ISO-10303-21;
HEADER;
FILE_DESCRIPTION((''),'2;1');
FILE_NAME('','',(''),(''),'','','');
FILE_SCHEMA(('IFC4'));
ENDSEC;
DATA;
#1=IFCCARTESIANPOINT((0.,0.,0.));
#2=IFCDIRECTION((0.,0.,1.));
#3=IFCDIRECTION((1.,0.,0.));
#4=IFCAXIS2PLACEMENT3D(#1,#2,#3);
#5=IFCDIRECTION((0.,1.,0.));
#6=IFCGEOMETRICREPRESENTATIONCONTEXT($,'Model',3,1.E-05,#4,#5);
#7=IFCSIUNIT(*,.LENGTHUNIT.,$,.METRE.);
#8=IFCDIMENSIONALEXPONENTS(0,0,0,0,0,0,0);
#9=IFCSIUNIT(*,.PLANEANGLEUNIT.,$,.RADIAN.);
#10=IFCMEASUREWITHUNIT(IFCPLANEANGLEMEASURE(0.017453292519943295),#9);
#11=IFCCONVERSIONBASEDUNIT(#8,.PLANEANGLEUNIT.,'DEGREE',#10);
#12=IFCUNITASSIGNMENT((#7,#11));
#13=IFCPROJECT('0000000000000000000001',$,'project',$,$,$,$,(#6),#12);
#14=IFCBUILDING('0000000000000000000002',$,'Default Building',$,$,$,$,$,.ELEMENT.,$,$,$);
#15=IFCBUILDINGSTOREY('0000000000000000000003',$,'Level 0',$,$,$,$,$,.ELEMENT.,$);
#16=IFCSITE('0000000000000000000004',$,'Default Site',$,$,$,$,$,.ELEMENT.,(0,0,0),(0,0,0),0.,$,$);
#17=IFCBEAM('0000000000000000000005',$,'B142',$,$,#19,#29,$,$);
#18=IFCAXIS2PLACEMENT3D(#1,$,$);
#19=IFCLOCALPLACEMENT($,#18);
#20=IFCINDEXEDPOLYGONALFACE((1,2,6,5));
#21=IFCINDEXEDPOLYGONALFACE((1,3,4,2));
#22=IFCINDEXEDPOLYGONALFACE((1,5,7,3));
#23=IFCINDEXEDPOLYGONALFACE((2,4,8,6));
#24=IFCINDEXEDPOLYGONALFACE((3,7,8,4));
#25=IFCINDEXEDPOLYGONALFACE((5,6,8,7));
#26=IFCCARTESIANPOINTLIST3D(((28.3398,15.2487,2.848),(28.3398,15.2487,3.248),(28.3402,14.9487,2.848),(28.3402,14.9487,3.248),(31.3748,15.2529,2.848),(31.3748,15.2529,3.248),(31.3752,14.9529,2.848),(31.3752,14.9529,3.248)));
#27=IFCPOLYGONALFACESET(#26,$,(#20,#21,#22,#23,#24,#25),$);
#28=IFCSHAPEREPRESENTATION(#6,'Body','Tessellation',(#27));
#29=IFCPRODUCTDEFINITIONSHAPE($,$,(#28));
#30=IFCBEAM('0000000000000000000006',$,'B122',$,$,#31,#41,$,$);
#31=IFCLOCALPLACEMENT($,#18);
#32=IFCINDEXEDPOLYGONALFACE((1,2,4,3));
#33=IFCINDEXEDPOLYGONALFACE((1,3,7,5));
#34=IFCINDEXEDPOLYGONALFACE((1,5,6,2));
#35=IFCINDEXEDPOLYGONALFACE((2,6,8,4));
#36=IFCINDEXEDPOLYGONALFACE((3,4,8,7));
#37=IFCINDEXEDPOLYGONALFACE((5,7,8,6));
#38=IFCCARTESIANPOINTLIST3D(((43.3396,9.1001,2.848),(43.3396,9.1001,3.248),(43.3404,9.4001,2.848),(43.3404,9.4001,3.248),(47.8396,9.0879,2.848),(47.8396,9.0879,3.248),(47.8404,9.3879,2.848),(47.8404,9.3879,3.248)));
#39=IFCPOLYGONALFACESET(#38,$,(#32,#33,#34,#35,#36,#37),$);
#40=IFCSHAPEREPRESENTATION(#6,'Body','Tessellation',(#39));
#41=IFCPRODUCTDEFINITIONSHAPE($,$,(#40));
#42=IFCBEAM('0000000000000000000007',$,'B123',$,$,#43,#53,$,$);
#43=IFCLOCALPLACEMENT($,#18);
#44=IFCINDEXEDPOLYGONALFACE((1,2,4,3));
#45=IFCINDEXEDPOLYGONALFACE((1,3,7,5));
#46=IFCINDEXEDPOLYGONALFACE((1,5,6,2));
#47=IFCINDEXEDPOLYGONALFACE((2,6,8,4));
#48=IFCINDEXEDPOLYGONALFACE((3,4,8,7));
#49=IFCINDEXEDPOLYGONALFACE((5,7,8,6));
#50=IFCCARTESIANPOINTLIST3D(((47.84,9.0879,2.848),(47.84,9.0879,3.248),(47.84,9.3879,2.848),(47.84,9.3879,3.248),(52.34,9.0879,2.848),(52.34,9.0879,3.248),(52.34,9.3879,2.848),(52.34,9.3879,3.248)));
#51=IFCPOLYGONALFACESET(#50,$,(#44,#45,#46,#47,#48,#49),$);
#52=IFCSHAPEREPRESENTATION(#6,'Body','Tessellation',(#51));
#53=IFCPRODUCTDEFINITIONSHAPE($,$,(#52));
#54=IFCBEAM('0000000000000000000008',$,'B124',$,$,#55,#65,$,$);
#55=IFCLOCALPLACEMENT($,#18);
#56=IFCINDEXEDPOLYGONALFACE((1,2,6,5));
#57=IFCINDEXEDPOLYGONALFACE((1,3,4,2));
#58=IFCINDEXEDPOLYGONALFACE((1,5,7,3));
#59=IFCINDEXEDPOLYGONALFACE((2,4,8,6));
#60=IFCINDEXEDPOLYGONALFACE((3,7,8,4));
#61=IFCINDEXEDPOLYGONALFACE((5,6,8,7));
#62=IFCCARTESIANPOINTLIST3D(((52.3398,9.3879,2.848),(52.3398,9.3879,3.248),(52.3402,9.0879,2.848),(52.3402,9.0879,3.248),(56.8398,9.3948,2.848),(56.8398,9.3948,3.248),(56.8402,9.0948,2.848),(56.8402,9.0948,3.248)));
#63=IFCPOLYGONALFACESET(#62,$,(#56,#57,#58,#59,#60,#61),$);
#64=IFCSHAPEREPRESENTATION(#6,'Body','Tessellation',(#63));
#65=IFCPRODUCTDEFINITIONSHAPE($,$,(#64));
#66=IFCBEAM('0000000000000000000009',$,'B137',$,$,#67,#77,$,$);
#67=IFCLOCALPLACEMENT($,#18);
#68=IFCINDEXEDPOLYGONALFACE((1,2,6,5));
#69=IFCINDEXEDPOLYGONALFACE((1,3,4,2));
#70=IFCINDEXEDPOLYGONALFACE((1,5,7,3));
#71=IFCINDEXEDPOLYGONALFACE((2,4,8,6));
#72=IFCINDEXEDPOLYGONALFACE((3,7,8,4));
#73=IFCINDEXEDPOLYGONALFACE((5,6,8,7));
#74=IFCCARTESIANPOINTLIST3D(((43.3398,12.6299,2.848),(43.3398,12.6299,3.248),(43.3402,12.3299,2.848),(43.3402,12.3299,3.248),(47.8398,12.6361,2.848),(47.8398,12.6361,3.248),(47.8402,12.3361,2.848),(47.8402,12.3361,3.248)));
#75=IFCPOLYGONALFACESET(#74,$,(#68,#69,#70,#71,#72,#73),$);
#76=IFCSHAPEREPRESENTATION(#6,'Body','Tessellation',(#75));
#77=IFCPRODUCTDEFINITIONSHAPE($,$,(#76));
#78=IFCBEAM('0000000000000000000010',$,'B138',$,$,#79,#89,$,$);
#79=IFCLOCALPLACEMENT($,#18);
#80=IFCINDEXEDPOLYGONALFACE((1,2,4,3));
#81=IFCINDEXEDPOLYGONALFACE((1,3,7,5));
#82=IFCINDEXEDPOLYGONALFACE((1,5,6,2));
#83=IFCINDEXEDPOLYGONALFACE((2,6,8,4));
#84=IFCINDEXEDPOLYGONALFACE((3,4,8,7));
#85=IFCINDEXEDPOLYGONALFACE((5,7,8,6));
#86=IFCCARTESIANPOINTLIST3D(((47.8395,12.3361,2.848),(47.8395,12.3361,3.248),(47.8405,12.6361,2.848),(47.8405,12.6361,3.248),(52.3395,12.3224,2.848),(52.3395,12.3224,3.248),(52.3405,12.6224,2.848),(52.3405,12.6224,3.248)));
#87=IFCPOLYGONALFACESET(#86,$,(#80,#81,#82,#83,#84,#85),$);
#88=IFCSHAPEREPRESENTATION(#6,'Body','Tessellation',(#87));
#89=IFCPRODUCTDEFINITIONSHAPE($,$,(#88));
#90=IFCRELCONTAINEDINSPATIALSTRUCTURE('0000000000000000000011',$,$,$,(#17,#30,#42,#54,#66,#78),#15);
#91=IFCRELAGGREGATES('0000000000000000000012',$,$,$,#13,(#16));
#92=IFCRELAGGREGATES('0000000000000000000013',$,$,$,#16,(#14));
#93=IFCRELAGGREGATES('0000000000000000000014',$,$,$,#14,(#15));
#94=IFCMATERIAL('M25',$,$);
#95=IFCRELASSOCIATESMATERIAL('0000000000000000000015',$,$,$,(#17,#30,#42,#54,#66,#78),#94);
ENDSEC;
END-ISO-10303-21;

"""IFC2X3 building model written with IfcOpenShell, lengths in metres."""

from ifc_helpers import new_model, entity, si_unit, converted_unit, direction, frame, frame_2d, origin_with_axes, place, context, project, spatial, rectangle, extrude, material, element, save


model = new_model("IFC2X3")

# Units and contexts
model_context = context("Model", 3, precision=1e-05, world=origin_with_axes(), true_north=direction((0.0, 1.0, 0.0)))
ifc_project = project(units=[si_unit("LENGTHUNIT", "METRE"), converted_unit("PLANEANGLEUNIT", "DEGREE", entity("IfcPlaneAngleMeasure", 0.017453292519943295), si_unit("PLANEANGLEUNIT", "RADIAN"), dimensions=[0, 0, 0, 0, 0, 0, 0])], contexts=[model_context])

# Site, building, storey
site = spatial("IfcSite", under=ifc_project, Name="Default Site", CompositionType="ELEMENT", RefLatitude=(0, 0, 0), RefLongitude=(0, 0, 0), RefElevation=0.0)
building = spatial("IfcBuilding", under=site, Name="Default Building", CompositionType="ELEMENT")
storey = spatial("IfcBuildingStorey", under=building, Name="Level 0", CompositionType="ELEMENT")

# Beams
ifc_material = material(Name="M25")
placement = place(None, origin_with_axes())
element("IfcBeam", 1, at=placement, inside=storey, material=ifc_material, Name="B142", context=model_context, shape_type="SweptSolid", body=[
    extrude(rectangle(XDim=0.3, YDim=0.4, at=frame_2d((0.0, 0.0), x_axis=(0.0, 1.0, 0.0))), frame((31.375, 15.1029, 3.048), z_axis=(-0.999999, -0.001391, 0.0), x_axis=(0.0, 0.0, -1.0)), (0.0, 0.0, 1.0), 3.035),
])
element("IfcBeam", 2, at=placement, inside=storey, material=ifc_material, Name="B122", context=model_context, shape_type="SweptSolid", body=[
    extrude(rectangle(XDim=0.3, YDim=0.4, at=frame_2d((0.0, 0.0), x_axis=(0.0, 1.0, 0.0))), frame((43.34, 9.2501, 3.048), z_axis=(0.999996, -0.002702, 0.0), x_axis=(0.0, 0.0, -1.0)), (0.0, 0.0, 1.0), 4.5),
])
element("IfcBeam", 3, at=placement, inside=storey, material=ifc_material, Name="B123", context=model_context, shape_type="SweptSolid", body=[
    extrude(rectangle(XDim=0.3, YDim=0.4, at=frame_2d((0.0, 0.0), x_axis=(0.0, 1.0, 0.0))), frame((47.84, 9.2379, 3.048), z_axis=(1.0, 0.0, 0.0), x_axis=(0.0, 0.0, -1.0)), (0.0, 0.0, 1.0), 4.5),
])
element("IfcBeam", 4, at=placement, inside=storey, material=ifc_material, Name="B124", context=model_context, shape_type="SweptSolid", body=[
    extrude(rectangle(XDim=0.3, YDim=0.4, at=frame_2d((0.0, 0.0), x_axis=(0.0, 1.0, 0.0))), frame((52.34, 9.2379, 3.048), z_axis=(0.999999, 0.001537, 0.0), x_axis=(0.0, 0.0, -1.0)), (0.0, 0.0, 1.0), 4.5),
])
element("IfcBeam", 5, at=placement, inside=storey, material=ifc_material, Name="B137", context=model_context, shape_type="SweptSolid", body=[
    extrude(rectangle(XDim=0.3, YDim=0.4, at=frame_2d((0.0, 0.0), x_axis=(0.0, 1.0, 0.0))), frame((43.34, 12.4799, 3.048), z_axis=(0.999999, 0.001374, 0.0), x_axis=(0.0, 0.0, -1.0)), (0.0, 0.0, 1.0), 4.5),
])
element("IfcBeam", 6, at=placement, inside=storey, material=ifc_material, Name="B138", context=model_context, shape_type="SweptSolid", body=[
    extrude(rectangle(XDim=0.3, YDim=0.4, at=frame_2d((0.0, 0.0), x_axis=(0.0, 1.0, 0.0))), frame((47.84, 12.4861, 3.048), z_axis=(0.999995, -0.003045, 0.0), x_axis=(0.0, 0.0, -1.0)), (0.0, 0.0, 1.0), 4.5),
])

save(model, "model.ifc")
